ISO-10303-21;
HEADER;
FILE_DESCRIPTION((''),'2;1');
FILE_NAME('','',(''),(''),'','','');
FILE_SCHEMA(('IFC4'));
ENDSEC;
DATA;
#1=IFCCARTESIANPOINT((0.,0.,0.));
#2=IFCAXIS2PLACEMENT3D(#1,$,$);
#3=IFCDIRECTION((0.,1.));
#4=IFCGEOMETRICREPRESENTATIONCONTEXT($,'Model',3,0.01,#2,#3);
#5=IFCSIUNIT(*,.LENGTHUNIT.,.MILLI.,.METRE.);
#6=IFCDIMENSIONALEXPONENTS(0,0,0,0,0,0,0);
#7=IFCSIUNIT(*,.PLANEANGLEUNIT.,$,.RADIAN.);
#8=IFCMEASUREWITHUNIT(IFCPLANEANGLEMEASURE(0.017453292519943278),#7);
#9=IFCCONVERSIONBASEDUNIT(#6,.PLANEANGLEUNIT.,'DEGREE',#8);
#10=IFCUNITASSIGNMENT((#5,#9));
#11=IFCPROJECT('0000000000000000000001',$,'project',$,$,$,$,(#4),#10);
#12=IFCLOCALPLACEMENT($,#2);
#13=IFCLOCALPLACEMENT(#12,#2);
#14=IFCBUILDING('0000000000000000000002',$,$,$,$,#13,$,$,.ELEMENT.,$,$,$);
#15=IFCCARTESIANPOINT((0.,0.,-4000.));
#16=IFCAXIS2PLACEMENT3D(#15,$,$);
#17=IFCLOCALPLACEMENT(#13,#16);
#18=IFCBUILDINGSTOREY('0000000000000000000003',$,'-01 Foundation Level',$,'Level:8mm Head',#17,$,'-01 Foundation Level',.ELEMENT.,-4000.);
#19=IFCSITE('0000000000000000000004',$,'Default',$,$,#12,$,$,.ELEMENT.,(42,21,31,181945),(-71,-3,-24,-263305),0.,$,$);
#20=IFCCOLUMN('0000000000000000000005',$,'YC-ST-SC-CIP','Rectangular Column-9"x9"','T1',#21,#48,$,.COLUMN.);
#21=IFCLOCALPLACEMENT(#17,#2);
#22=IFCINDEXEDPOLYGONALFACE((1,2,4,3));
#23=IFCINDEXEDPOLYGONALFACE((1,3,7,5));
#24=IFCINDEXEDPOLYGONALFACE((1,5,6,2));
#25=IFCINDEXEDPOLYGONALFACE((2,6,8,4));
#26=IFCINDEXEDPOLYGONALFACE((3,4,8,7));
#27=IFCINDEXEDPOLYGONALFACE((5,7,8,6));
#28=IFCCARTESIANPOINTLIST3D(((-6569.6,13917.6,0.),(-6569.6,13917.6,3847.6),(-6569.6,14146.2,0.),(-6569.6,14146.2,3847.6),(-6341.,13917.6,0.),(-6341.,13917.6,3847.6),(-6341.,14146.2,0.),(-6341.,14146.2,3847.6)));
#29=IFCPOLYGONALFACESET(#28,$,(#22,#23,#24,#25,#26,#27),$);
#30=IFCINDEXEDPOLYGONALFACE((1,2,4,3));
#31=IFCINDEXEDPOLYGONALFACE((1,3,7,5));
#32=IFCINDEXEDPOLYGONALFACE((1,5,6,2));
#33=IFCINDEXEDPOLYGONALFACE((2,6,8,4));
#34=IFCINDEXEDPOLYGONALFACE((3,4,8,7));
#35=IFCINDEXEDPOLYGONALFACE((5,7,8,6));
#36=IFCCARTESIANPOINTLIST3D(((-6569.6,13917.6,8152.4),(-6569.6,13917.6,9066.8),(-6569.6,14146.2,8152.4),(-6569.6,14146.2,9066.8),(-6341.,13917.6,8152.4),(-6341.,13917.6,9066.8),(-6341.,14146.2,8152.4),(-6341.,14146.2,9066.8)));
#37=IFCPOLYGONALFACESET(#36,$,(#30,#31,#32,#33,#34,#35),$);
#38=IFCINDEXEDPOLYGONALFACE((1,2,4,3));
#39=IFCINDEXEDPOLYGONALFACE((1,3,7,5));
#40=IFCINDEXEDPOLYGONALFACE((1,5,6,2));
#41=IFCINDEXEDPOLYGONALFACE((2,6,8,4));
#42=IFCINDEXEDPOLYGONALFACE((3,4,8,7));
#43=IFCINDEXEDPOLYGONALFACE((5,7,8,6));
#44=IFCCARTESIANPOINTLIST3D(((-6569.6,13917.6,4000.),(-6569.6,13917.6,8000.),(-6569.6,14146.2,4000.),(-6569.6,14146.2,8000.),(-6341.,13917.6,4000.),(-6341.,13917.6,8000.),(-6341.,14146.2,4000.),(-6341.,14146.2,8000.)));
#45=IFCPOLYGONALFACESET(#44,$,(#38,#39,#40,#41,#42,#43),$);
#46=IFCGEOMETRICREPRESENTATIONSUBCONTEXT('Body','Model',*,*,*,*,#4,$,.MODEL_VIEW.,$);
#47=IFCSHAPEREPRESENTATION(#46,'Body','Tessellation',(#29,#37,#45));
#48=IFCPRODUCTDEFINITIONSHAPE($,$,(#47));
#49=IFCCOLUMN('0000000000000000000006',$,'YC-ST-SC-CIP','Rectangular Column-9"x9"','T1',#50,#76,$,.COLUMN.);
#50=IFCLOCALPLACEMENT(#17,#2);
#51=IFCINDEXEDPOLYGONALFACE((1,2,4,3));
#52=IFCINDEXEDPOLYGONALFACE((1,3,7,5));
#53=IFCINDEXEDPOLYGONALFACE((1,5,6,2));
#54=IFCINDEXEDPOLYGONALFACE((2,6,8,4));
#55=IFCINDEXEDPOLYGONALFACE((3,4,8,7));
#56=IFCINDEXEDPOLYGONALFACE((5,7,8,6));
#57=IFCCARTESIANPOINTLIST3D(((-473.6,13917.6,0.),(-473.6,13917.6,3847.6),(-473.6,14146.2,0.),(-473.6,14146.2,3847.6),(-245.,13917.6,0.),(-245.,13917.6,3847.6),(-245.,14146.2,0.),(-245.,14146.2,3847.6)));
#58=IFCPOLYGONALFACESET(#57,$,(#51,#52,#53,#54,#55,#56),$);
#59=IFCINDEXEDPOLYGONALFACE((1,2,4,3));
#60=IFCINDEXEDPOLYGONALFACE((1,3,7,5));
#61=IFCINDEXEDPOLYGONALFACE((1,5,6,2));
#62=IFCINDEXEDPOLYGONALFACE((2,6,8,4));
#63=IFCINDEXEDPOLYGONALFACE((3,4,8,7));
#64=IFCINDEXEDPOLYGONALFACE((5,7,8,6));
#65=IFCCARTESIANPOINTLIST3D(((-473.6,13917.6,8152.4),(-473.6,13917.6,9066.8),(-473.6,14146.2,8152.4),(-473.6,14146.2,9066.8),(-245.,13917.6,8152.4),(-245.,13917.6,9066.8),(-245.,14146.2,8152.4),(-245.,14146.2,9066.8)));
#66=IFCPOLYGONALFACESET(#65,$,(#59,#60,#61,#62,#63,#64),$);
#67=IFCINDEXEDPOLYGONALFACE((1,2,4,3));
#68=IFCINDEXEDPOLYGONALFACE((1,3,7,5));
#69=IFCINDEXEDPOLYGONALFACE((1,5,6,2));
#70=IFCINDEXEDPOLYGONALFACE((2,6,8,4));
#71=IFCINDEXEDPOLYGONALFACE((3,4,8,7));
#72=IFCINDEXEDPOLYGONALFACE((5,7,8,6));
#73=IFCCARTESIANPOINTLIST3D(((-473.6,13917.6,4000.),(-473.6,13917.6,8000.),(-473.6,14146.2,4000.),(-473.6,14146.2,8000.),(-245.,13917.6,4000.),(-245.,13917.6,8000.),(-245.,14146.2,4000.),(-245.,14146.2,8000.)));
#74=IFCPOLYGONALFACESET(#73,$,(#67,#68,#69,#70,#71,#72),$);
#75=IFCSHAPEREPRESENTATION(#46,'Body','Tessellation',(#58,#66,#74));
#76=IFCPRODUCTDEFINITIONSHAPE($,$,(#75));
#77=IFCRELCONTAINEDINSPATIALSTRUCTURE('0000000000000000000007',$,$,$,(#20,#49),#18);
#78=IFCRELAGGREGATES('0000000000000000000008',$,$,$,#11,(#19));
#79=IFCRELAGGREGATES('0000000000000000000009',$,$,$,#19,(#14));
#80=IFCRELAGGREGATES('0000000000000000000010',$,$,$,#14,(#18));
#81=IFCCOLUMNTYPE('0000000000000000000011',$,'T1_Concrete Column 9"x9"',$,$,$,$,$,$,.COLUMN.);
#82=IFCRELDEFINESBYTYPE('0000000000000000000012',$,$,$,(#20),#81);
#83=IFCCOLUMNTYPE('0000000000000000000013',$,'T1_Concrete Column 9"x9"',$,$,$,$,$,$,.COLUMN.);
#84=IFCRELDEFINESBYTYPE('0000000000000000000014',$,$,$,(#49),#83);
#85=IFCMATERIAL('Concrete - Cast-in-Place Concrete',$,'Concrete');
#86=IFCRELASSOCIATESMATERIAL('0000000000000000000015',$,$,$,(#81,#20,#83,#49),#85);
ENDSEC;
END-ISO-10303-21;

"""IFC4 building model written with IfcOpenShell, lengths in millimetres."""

from ifc_helpers import new_model, entity, si_unit, converted_unit, direction, frame, origin, place, context, subcontext, project, spatial, indexed_curve, outline, extrude, source, transform, mapped, material, type_object, type_shapes, element, save


model = new_model("IFC4")

# Units and contexts
model_context = context("Model", 3, precision=0.01, world=origin(), true_north=direction((0.0, 1.0)))
body_context = subcontext(model_context, "Body", "Model", "MODEL_VIEW")
ifc_project = project(units=[si_unit("LENGTHUNIT", "METRE", prefix="MILLI"), converted_unit("PLANEANGLEUNIT", "DEGREE", entity("IfcPlaneAngleMeasure", 0.017453292519943278), si_unit("PLANEANGLEUNIT", "RADIAN"), dimensions=[0, 0, 0, 0, 0, 0, 0])], contexts=[model_context])

# Site, building, storey
site_placement = place(None, origin())
site = spatial("IfcSite", under=ifc_project, at=site_placement, Name="Default", CompositionType="ELEMENT", RefLatitude=(42, 21, 31, 181945), RefLongitude=(-71, -3, -24, -263305), RefElevation=0.0)
building_placement = place(site_placement, origin())
building = spatial("IfcBuilding", under=site, at=building_placement, CompositionType="ELEMENT")
storey_placement = place(building_placement, frame((0.0, 0.0, -4000.0)))
storey = spatial("IfcBuildingStorey", under=building, at=storey_placement, Name="-01 Foundation Level", ObjectType="Level:8mm Head", LongName="-01 Foundation Level", CompositionType="ELEMENT", Elevation=-4000.0)

# Shared definitions
ifc_material = material(Name="Concrete - Cast-in-Place Concrete", Category="Concrete")

# Columns
column_type_1 = type_object("IfcColumnType", Name="T1_Concrete Column 9\"x9\"", PredefinedType="COLUMN", material=ifc_material)
shared_shape_1 = source(origin(), body_context, "Body", "SweptSolid", [
    extrude(outline(indexed_curve([(-114.3, -114.3), (114.3, -114.3), (114.3, 114.3), (-114.3, 114.3), (-114.3, -114.3)], self_intersect=False)), frame((-6455.3, 14031.9, -4000.0), z_axis=(0.0, 0.0, 1.0), x_axis=(-1.0, 0.0, 0.0)), (0.0, 0.0, 1.0), 3847.6),
    extrude(outline(indexed_curve([(-114.3, -114.3), (114.3, -114.3), (114.3, 114.3), (-114.3, 114.3), (-114.3, -114.3)], self_intersect=False)), frame((-6455.3, 14031.9, 4152.4), z_axis=(0.0, 0.0, 1.0), x_axis=(-1.0, 0.0, 0.0)), (0.0, 0.0, 1.0), 914.4),
    extrude(outline(indexed_curve([(-114.3, -114.3), (114.3, -114.3), (114.3, 114.3), (-114.3, 114.3), (-114.3, -114.3)], self_intersect=False)), frame((-6455.3, 14031.9, 0.0), z_axis=(0.0, 0.0, 1.0), x_axis=(-1.0, 0.0, 0.0)), (0.0, 0.0, 1.0), 4000.0),
])
type_shapes(column_type_1, [shared_shape_1])
column_1_placement = place(storey_placement, frame((0.0, 0.0, 4000.0)))
element("IfcColumn", 1, at=column_1_placement, inside=storey, type_object=column_type_1, material=ifc_material, Name="YC-ST-SC-CIP", Description="Rectangular Column-9\"x9\"", ObjectType="T1", PredefinedType="COLUMN", context=body_context, shape_type="MappedRepresentation", body=[
    mapped(shared_shape_1, transform((0.0, 0.0, 0.0), scale=1.0)),
])
column_type_2 = type_object("IfcColumnType", Name="T1_Concrete Column 9\"x9\"", PredefinedType="COLUMN", material=ifc_material)
shared_shape_2 = source(origin(), body_context, "Body", "SweptSolid", [
    extrude(outline(indexed_curve([(-114.3, -114.3), (114.3, -114.3), (114.3, 114.3), (-114.3, 114.3), (-114.3, -114.3)], self_intersect=False)), frame((-359.3, 14031.9, -4000.0), z_axis=(0.0, 0.0, 1.0), x_axis=(-1.0, 0.0, 0.0)), (0.0, 0.0, 1.0), 3847.6),
    extrude(outline(indexed_curve([(-114.3, -114.3), (114.3, -114.3), (114.3, 114.3), (-114.3, 114.3), (-114.3, -114.3)], self_intersect=False)), frame((-359.3, 14031.9, 4152.4), z_axis=(0.0, 0.0, 1.0), x_axis=(-1.0, 0.0, 0.0)), (0.0, 0.0, 1.0), 914.4),
    extrude(outline(indexed_curve([(-114.3, -114.3), (114.3, -114.3), (114.3, 114.3), (-114.3, 114.3), (-114.3, -114.3)], self_intersect=False)), frame((-359.3, 14031.9, 0.0), z_axis=(0.0, 0.0, 1.0), x_axis=(-1.0, 0.0, 0.0)), (0.0, 0.0, 1.0), 4000.0),
])
type_shapes(column_type_2, [shared_shape_2])
column_2_placement = place(storey_placement, frame((0.0, 0.0, 4000.0)))
element("IfcColumn", 2, at=column_2_placement, inside=storey, type_object=column_type_2, material=ifc_material, Name="YC-ST-SC-CIP", Description="Rectangular Column-9\"x9\"", ObjectType="T1", PredefinedType="COLUMN", context=body_context, shape_type="MappedRepresentation", body=[
    mapped(shared_shape_2, transform((0.0, 0.0, 0.0), scale=1.0)),
])

save(model, "model.ifc")
